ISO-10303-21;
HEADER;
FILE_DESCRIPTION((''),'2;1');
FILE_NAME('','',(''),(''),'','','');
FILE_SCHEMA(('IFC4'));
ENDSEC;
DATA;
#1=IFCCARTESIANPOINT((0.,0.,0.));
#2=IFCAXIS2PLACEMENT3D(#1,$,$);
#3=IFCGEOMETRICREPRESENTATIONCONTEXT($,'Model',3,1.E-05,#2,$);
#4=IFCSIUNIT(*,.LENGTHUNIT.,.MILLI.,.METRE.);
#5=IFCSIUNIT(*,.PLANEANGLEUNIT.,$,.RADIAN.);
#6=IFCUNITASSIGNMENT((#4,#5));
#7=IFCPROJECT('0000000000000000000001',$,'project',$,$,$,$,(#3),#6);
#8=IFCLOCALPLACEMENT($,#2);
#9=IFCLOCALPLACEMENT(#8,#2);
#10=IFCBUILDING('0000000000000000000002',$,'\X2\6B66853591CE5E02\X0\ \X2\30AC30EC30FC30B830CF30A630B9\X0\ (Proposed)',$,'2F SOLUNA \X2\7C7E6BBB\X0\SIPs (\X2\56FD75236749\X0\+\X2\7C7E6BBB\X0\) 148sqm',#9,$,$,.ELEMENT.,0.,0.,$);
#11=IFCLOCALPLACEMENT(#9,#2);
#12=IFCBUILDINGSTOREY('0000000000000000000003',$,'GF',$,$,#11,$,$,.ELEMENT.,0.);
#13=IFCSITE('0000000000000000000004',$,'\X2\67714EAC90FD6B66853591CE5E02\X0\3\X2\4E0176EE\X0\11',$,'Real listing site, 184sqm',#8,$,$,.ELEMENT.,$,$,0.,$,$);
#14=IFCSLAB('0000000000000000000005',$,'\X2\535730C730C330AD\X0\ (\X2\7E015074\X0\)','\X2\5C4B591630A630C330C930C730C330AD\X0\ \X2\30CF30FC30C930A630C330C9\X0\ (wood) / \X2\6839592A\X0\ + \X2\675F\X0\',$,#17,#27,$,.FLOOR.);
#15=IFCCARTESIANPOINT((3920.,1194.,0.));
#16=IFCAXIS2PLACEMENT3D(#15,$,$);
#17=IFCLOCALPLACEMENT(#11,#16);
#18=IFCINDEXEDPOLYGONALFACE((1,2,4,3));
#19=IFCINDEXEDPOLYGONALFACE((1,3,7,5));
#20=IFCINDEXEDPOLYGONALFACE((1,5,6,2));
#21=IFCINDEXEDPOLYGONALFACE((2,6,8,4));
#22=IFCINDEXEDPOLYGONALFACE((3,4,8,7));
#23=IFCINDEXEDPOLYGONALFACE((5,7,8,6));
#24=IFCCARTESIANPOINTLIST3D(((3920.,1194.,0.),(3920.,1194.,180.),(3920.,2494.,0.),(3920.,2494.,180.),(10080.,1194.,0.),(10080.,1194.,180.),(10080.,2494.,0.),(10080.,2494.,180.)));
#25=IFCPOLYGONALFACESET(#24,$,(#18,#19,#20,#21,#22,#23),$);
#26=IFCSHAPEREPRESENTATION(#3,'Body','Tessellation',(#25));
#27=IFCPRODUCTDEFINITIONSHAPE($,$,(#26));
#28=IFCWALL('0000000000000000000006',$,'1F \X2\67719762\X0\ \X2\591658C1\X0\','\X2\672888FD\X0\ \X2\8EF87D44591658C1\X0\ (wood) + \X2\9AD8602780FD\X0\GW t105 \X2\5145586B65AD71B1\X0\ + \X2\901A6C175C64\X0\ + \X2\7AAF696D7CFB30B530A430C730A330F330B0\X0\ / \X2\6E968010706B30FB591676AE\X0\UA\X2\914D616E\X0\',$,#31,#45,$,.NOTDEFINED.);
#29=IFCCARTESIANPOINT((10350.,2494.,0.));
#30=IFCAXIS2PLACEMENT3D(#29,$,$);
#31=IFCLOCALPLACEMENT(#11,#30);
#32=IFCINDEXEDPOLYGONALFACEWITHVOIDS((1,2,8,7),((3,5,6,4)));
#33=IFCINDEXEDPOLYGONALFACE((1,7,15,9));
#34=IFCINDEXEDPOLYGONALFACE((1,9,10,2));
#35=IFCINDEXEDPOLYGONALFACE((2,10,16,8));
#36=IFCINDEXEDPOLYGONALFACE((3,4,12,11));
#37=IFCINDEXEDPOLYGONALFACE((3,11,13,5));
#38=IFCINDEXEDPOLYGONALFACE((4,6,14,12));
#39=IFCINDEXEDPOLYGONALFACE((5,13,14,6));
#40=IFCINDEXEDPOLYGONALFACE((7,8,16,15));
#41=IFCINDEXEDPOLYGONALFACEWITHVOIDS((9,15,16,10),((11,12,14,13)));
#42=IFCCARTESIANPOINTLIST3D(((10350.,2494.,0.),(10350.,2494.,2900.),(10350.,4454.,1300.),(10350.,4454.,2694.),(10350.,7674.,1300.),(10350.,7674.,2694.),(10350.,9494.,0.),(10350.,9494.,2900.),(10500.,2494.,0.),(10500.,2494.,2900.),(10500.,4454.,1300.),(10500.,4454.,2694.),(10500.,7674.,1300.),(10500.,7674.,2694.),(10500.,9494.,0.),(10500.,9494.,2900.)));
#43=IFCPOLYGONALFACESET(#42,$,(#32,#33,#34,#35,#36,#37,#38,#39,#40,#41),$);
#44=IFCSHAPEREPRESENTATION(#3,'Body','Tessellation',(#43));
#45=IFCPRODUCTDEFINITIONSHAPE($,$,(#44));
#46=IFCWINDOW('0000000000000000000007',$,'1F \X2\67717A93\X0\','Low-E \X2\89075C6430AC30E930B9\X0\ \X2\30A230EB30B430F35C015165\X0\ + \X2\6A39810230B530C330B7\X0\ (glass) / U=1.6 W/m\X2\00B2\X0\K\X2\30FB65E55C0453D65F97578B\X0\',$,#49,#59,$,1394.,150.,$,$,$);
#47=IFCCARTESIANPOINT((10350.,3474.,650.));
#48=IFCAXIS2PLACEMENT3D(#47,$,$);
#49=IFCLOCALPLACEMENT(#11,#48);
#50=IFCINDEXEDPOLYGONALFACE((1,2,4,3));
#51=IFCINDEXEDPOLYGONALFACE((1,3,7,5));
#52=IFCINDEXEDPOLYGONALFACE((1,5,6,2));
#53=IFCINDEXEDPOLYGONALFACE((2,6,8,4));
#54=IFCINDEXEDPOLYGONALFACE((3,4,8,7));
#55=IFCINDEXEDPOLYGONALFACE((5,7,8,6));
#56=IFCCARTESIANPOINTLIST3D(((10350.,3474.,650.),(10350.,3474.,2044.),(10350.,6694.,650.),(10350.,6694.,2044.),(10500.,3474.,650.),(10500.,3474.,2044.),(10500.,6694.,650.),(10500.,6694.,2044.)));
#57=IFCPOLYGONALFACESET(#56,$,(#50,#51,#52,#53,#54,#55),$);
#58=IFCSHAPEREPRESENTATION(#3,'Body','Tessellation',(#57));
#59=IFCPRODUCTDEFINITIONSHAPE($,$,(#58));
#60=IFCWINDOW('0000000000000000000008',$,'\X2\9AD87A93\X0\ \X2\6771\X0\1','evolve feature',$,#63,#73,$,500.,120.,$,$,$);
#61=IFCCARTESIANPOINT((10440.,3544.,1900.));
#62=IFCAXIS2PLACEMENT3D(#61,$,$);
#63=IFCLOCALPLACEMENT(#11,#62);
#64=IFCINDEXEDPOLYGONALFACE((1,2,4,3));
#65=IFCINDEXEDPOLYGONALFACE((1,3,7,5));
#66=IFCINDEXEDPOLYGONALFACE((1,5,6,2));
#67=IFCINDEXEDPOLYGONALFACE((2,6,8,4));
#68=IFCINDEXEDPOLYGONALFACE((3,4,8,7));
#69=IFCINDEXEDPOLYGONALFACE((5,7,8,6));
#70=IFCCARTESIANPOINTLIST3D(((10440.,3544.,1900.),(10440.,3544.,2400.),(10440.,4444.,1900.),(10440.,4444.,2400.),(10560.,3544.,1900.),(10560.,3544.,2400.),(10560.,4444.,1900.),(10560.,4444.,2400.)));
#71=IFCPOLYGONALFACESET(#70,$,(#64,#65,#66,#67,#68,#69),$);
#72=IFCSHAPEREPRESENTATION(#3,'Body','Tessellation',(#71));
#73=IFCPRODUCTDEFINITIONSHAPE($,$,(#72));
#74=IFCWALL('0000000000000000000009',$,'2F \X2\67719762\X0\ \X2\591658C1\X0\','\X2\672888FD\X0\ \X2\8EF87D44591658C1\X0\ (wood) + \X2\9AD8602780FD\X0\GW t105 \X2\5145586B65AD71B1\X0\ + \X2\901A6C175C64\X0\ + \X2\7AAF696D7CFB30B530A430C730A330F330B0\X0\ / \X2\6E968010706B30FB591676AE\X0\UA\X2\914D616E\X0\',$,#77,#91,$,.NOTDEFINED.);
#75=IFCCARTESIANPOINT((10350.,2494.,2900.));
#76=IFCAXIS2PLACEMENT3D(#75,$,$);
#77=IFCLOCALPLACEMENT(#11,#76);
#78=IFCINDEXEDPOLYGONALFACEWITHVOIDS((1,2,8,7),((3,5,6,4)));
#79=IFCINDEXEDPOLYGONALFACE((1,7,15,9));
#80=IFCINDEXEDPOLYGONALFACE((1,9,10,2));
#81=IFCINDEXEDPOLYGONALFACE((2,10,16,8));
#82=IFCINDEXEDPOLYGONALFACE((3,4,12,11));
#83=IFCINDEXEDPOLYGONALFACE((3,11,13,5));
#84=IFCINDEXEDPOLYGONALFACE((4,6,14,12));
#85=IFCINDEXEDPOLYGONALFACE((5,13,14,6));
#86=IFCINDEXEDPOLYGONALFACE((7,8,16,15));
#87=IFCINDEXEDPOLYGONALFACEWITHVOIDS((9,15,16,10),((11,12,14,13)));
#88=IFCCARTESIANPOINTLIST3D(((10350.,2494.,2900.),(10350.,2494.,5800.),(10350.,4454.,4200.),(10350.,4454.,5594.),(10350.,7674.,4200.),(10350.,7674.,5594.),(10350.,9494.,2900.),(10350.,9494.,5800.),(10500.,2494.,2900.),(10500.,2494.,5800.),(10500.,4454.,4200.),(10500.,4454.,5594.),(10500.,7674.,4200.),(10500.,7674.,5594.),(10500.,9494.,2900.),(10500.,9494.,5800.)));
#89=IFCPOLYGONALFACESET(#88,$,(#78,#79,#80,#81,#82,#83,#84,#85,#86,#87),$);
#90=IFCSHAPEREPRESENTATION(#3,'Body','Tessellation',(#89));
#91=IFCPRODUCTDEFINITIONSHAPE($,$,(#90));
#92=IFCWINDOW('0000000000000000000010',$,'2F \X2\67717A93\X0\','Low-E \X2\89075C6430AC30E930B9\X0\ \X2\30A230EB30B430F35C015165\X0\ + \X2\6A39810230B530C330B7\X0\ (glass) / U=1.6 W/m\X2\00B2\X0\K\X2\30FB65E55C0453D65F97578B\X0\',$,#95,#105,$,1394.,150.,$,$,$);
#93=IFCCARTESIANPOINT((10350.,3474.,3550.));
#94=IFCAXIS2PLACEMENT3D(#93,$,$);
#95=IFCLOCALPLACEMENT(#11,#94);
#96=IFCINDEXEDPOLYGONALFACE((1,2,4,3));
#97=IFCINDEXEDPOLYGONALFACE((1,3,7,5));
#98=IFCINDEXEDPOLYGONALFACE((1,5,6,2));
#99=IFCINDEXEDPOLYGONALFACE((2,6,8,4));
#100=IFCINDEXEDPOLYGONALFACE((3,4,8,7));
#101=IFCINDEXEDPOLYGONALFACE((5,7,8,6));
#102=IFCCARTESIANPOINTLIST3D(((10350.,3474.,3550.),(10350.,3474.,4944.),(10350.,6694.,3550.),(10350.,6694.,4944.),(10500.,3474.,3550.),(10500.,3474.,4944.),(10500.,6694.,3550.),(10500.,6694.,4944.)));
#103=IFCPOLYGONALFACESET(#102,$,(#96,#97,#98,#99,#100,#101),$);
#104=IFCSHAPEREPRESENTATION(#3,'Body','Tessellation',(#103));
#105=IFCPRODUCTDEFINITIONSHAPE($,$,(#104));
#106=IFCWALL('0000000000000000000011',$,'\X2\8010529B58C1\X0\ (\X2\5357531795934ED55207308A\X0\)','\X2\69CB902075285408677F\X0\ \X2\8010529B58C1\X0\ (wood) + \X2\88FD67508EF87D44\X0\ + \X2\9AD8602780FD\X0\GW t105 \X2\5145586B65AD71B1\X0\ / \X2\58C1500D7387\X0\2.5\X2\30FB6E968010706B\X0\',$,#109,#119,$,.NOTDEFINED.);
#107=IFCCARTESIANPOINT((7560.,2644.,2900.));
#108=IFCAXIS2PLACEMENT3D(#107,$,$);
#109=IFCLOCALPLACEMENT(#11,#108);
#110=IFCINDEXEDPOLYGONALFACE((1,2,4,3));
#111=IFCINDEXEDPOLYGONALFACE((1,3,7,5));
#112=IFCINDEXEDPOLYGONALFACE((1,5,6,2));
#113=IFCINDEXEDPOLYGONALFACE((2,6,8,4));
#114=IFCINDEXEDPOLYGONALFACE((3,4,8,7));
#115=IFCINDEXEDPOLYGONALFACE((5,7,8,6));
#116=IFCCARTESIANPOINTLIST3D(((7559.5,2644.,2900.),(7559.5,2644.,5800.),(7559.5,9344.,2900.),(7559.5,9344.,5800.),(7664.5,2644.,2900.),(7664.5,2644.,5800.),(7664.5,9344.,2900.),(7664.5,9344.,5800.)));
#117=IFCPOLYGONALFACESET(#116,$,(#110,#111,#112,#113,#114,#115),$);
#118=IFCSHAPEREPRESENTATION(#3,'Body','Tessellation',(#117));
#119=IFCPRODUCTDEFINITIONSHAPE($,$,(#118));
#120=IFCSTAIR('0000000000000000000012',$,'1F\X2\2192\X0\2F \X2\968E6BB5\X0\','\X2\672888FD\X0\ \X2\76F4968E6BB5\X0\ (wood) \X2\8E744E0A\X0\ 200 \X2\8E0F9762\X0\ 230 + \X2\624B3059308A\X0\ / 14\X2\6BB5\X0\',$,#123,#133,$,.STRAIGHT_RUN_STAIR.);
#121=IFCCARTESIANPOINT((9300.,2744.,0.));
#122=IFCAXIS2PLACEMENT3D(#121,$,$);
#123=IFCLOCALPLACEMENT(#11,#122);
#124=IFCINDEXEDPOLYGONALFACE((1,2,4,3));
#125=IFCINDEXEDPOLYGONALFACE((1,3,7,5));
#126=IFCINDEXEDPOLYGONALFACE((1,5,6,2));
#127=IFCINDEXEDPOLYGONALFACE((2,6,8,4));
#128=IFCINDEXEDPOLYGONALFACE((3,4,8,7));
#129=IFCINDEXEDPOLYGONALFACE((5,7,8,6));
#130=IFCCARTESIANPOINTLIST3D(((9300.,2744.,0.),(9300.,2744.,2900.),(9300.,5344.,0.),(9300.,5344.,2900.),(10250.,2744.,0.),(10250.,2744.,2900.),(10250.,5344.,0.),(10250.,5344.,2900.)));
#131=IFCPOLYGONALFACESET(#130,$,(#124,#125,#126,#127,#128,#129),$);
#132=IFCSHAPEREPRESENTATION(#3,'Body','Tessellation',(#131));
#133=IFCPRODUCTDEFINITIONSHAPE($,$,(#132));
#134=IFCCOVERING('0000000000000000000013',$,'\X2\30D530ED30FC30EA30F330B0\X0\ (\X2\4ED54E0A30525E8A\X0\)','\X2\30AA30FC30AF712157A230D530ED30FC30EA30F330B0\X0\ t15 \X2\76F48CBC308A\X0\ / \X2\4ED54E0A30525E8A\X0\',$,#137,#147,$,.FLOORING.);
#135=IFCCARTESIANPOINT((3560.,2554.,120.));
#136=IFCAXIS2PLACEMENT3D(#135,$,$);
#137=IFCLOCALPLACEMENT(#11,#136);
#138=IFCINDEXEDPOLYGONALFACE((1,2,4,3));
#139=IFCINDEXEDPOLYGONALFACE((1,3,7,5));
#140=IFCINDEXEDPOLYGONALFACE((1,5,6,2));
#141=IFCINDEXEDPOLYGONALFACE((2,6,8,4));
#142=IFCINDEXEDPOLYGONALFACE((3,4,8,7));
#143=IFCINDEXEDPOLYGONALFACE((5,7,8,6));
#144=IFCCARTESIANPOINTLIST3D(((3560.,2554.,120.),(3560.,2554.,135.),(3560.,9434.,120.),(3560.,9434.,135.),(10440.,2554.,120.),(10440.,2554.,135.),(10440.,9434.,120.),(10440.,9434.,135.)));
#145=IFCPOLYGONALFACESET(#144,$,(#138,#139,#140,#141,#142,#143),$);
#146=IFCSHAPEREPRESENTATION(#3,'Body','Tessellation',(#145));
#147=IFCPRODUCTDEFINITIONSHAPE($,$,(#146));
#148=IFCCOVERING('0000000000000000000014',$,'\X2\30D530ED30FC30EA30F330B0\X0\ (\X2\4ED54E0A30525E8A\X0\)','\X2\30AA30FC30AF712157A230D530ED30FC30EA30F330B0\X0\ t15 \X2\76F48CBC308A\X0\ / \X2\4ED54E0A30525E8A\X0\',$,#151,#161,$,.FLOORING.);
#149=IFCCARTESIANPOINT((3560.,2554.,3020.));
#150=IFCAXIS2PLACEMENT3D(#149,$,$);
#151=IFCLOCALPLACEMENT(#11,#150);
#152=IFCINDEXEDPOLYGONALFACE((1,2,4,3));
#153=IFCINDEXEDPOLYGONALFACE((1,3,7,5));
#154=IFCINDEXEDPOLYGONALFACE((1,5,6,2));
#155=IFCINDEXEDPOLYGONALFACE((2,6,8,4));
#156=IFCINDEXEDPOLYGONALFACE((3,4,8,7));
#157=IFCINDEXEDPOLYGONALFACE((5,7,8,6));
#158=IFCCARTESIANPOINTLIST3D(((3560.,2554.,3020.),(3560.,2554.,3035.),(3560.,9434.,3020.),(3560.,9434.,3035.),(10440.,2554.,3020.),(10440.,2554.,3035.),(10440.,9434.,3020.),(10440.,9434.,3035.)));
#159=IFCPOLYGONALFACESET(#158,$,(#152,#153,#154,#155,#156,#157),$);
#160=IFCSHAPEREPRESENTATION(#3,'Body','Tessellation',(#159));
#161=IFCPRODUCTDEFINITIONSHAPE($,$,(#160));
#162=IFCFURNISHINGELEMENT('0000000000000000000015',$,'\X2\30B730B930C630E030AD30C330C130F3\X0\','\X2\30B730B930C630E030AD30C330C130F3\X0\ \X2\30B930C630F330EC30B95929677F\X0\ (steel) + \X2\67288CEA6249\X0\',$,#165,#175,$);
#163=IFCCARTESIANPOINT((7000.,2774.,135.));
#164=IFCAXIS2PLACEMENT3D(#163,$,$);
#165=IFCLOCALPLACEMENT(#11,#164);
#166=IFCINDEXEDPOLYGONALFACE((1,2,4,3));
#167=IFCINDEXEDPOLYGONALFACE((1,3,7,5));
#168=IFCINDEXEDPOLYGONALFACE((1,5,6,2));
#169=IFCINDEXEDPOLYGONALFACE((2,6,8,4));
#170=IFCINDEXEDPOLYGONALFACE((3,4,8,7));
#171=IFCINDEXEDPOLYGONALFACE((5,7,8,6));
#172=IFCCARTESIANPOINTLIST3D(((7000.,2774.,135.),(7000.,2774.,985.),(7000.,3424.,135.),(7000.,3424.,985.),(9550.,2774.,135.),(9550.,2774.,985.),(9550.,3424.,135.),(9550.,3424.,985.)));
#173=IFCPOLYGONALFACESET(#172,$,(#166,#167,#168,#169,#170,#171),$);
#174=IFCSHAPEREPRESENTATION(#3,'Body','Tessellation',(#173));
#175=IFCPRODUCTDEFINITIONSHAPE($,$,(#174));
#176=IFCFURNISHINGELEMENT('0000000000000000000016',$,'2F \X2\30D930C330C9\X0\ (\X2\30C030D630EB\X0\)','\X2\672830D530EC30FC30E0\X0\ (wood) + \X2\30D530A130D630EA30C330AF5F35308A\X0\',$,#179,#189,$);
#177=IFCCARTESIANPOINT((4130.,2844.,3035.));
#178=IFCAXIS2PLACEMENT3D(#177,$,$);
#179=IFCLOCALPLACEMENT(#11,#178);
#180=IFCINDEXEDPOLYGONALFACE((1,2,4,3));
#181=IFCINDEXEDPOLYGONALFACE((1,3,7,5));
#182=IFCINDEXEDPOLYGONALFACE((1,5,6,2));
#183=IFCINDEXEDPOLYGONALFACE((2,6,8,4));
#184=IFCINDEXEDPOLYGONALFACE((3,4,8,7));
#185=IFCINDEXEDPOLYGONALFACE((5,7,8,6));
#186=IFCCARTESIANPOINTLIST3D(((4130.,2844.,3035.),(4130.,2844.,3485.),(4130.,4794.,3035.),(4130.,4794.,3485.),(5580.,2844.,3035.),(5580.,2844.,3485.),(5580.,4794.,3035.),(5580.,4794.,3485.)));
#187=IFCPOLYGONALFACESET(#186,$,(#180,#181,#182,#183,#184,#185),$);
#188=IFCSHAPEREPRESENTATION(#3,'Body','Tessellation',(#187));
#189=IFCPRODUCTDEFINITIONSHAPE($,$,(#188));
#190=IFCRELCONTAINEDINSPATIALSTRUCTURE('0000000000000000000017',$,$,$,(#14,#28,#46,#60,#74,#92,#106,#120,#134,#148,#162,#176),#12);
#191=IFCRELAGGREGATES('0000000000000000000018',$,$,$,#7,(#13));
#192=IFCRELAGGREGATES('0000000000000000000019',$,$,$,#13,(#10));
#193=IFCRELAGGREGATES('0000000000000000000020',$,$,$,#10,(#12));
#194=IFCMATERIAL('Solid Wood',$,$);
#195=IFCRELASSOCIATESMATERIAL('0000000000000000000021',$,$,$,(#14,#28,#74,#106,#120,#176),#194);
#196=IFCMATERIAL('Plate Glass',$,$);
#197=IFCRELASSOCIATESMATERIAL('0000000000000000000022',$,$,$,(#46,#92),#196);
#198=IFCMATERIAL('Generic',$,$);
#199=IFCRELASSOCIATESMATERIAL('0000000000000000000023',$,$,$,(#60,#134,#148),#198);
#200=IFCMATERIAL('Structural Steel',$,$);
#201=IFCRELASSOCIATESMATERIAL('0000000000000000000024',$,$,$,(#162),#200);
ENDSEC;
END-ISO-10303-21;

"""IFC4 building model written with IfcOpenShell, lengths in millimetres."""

from ifc_helpers import new_model, si_unit, frame, frame_2d, origin, place, context, project, spatial, rectangle, extrude, material, element, fill, save


model = new_model("IFC4")

# Units and contexts
model_context = context("Model", 3, precision=1e-05, world=origin())
ifc_project = project(units=[si_unit("LENGTHUNIT", "METRE", prefix="MILLI"), si_unit("PLANEANGLEUNIT", "RADIAN")], contexts=[model_context])

# Site, building, storey
site_placement = place(None, origin())
site = spatial("IfcSite", under=ifc_project, at=site_placement, Name="東京都武蔵野市3丁目11", ObjectType="Real listing site, 184sqm", CompositionType="ELEMENT", RefElevation=0.0)
building_placement = place(site_placement, origin())
building = spatial("IfcBuilding", under=site, at=building_placement, Name="武蔵野市 ガレージハウス (Proposed)", ObjectType="2F SOLUNA 籾殻SIPs (国産杉+籾殻) 148sqm", CompositionType="ELEMENT", ElevationOfRefHeight=0.0, ElevationOfTerrain=0.0)
storey_placement = place(building_placement, origin())
storey = spatial("IfcBuildingStorey", under=building, at=storey_placement, Name="GF", CompositionType="ELEMENT", Elevation=0.0)

# Slab
ifc_material_1 = material(Name="Solid Wood")
slab_placement = place(storey_placement, frame((3920.0, 1194.0, 0.0)))
element("IfcSlab", 1, at=slab_placement, inside=storey, material=ifc_material_1, Name="南デッキ (縁側)", Description="屋外ウッドデッキ ハードウッド (wood) / 根太 + 束", PredefinedType="FLOOR", context=model_context, shape_type="SweptSolid", body=[
    extrude(rectangle(XDim=6160.0, YDim=1300.0, at=frame_2d((3080.0, 650.0))), frame((3920.0, 1194.0, 0.0)), (0.0, 0.0, 1.0), 180.0),
])

# Wall, openings, windows
wall_1_placement = place(storey_placement, frame((10350.0, 2494.0, 0.0)))
wall_1 = element("IfcWall", 2, at=wall_1_placement, inside=storey, material=ifc_material_1, Name="1F 東面 外壁", Description="木製 軸組外壁 (wood) + 高性能GW t105 充填断熱 + 通気層 + 窯業系サイディング / 準耐火・外皮UA配慮", PredefinedType="NOTDEFINED", context=model_context, shape_type="SweptSolid", body=[
    extrude(rectangle(XDim=150.0, YDim=7000.0, at=frame_2d((75.0, 3500.0))), frame((10350.0, 2494.0, 0.0)), (0.0, 0.0, 1.0), 2900.0),
])
opening_1_placement = place(storey_placement, frame((10350.0, 3474.0, 650.0)))
opening_1 = element("IfcOpeningElement", 3, at=opening_1_placement, cuts=wall_1, PredefinedType="NOTDEFINED", context=model_context, shape_type="SweptSolid", body=[
    extrude(rectangle(XDim=150.0, YDim=3220.0, at=frame_2d((75.0, 1610.0))), frame((10350.0, 3474.0, 650.0)), (0.0, 0.0, 1.0), 1394.0),
])
opening_2_placement = place(storey_placement, frame((10440.0, 3544.0, 1900.0)))
opening_2 = element("IfcOpeningElement", 4, at=opening_2_placement, cuts=wall_1, PredefinedType="NOTDEFINED", context=model_context, shape_type="SweptSolid", body=[
    extrude(rectangle(XDim=120.0, YDim=900.0, at=frame_2d((60.0, 450.0))), frame((10440.0, 3544.0, 1900.0)), (0.0, 0.0, 1.0), 500.0),
])
ifc_material_2 = material(Name="Plate Glass")
window_1_placement = place(storey_placement, frame((10350.0, 3474.0, 650.0)))
window_1 = element("IfcWindow", 5, at=window_1_placement, inside=storey, material=ifc_material_2, Name="1F 東窓", Description="Low-E 複層ガラス アルゴン封入 + 樹脂サッシ (glass) / U=1.6 W/m²K・日射取得型", OverallHeight=1394.0, OverallWidth=150.0, context=model_context, shape_type="SweptSolid", body=[
    extrude(rectangle(XDim=150.0, YDim=3220.0, at=frame_2d((75.0, 1610.0))), frame((10350.0, 3474.0, 650.0)), (0.0, 0.0, 1.0), 1394.0),
])
fill(opening_1, window_1)
ifc_material_3 = material(Name="Generic")
window_2_placement = place(storey_placement, frame((10440.0, 3544.0, 1900.0)))
window_2 = element("IfcWindow", 6, at=window_2_placement, inside=storey, material=ifc_material_3, Name="高窓 東1", Description="evolve feature", OverallHeight=500.0, OverallWidth=120.0, context=model_context, shape_type="SweptSolid", body=[
    extrude(rectangle(XDim=120.0, YDim=900.0, at=frame_2d((60.0, 450.0))), frame((10440.0, 3544.0, 1900.0)), (0.0, 0.0, 1.0), 500.0),
])
fill(opening_2, window_2)

# Wall, opening, window
wall_2_placement = place(storey_placement, frame((10350.0, 2494.0, 2900.0)))
wall_2 = element("IfcWall", 7, at=wall_2_placement, inside=storey, material=ifc_material_1, Name="2F 東面 外壁", Description="木製 軸組外壁 (wood) + 高性能GW t105 充填断熱 + 通気層 + 窯業系サイディング / 準耐火・外皮UA配慮", PredefinedType="NOTDEFINED", context=model_context, shape_type="SweptSolid", body=[
    extrude(rectangle(XDim=150.0, YDim=7000.0, at=frame_2d((75.0, 3500.0))), frame((10350.0, 2494.0, 2900.0)), (0.0, 0.0, 1.0), 2900.0),
])
opening_3_placement = place(storey_placement, frame((10350.0, 3474.0, 3550.0)))
opening_3 = element("IfcOpeningElement", 8, at=opening_3_placement, cuts=wall_2, PredefinedType="NOTDEFINED", context=model_context, shape_type="SweptSolid", body=[
    extrude(rectangle(XDim=150.0, YDim=3220.0, at=frame_2d((75.0, 1610.0))), frame((10350.0, 3474.0, 3550.0)), (0.0, 0.0, 1.0), 1394.0),
])
window_3_placement = place(storey_placement, frame((10350.0, 3474.0, 3550.0)))
window_3 = element("IfcWindow", 9, at=window_3_placement, inside=storey, material=ifc_material_2, Name="2F 東窓", Description="Low-E 複層ガラス アルゴン封入 + 樹脂サッシ (glass) / U=1.6 W/m²K・日射取得型", OverallHeight=1394.0, OverallWidth=150.0, context=model_context, shape_type="SweptSolid", body=[
    extrude(rectangle(XDim=150.0, YDim=3220.0, at=frame_2d((75.0, 1610.0))), frame((10350.0, 3474.0, 3550.0)), (0.0, 0.0, 1.0), 1394.0),
])
fill(opening_3, window_3)

# Wall
wall_3_placement = place(storey_placement, frame((7560.0, 2644.0, 2900.0)))
element("IfcWall", 10, at=wall_3_placement, inside=storey, material=ifc_material_1, Name="耐力壁 (南北間仕切り)", Description="構造用合板 耐力壁 (wood) + 製材軸組 + 高性能GW t105 充填断熱 / 壁倍率2.5・準耐火", PredefinedType="NOTDEFINED", context=model_context, shape_type="SweptSolid", body=[
    extrude(rectangle(XDim=105.0, YDim=6700.0, at=frame_2d((52.0, 3350.0))), frame((7560.0, 2644.0, 2900.0)), (0.0, 0.0, 1.0), 2900.0),
])

# Stair
stair_placement = place(storey_placement, frame((9300.0, 2744.0, 0.0)))
element("IfcStair", 11, at=stair_placement, inside=storey, material=ifc_material_1, Name="1F→2F 階段", Description="木製 直階段 (wood) 蹴上 200 踏面 230 + 手すり / 14段", PredefinedType="STRAIGHT_RUN_STAIR", context=model_context, shape_type="SweptSolid", body=[
    extrude(rectangle(XDim=950.0, YDim=2600.0, at=frame_2d((475.0, 1300.0))), frame((9300.0, 2744.0, 0.0)), (0.0, 0.0, 1.0), 2900.0),
])

# Coverings
covering_1_placement = place(storey_placement, frame((3560.0, 2554.0, 120.0)))
element("IfcCovering", 12, at=covering_1_placement, inside=storey, material=ifc_material_3, Name="フローリング (仕上げ床)", Description="オーク無垢フローリング t15 直貼り / 仕上げ床", PredefinedType="FLOORING", context=model_context, shape_type="SweptSolid", body=[
    extrude(rectangle(XDim=6880.0, YDim=6880.0, at=frame_2d((3440.0, 3440.0))), frame((3560.0, 2554.0, 120.0)), (0.0, 0.0, 1.0), 15.0),
])
covering_2_placement = place(storey_placement, frame((3560.0, 2554.0, 3020.0)))
element("IfcCovering", 13, at=covering_2_placement, inside=storey, material=ifc_material_3, Name="フローリング (仕上げ床)", Description="オーク無垢フローリング t15 直貼り / 仕上げ床", PredefinedType="FLOORING", context=model_context, shape_type="SweptSolid", body=[
    extrude(rectangle(XDim=6880.0, YDim=6880.0, at=frame_2d((3440.0, 3440.0))), frame((3560.0, 2554.0, 3020.0)), (0.0, 0.0, 1.0), 15.0),
])

# Furnishing elements
ifc_material_4 = material(Name="Structural Steel")
furnishing_1_placement = place(storey_placement, frame((7000.0, 2774.0, 135.0)))
element("IfcFurnishingElement", 14, at=furnishing_1_placement, inside=storey, material=ifc_material_4, Name="システムキッチン", Description="システムキッチン ステンレス天板 (steel) + 木質扉", context=model_context, shape_type="SweptSolid", body=[
    extrude(rectangle(XDim=2550.0, YDim=650.0, at=frame_2d((1275.0, 325.0))), frame((7000.0, 2774.0, 135.0)), (0.0, 0.0, 1.0), 850.0),
])
furnishing_2_placement = place(storey_placement, frame((4130.0, 2844.0, 3035.0)))
element("IfcFurnishingElement", 15, at=furnishing_2_placement, inside=storey, material=ifc_material_1, Name="2F ベッド (ダブル)", Description="木フレーム (wood) + ファブリック張り", context=model_context, shape_type="SweptSolid", body=[
    extrude(rectangle(XDim=1450.0, YDim=1950.0, at=frame_2d((725.0, 975.0))), frame((4130.0, 2844.0, 3035.0)), (0.0, 0.0, 1.0), 450.0),
])

save(model, "model.ifc")
